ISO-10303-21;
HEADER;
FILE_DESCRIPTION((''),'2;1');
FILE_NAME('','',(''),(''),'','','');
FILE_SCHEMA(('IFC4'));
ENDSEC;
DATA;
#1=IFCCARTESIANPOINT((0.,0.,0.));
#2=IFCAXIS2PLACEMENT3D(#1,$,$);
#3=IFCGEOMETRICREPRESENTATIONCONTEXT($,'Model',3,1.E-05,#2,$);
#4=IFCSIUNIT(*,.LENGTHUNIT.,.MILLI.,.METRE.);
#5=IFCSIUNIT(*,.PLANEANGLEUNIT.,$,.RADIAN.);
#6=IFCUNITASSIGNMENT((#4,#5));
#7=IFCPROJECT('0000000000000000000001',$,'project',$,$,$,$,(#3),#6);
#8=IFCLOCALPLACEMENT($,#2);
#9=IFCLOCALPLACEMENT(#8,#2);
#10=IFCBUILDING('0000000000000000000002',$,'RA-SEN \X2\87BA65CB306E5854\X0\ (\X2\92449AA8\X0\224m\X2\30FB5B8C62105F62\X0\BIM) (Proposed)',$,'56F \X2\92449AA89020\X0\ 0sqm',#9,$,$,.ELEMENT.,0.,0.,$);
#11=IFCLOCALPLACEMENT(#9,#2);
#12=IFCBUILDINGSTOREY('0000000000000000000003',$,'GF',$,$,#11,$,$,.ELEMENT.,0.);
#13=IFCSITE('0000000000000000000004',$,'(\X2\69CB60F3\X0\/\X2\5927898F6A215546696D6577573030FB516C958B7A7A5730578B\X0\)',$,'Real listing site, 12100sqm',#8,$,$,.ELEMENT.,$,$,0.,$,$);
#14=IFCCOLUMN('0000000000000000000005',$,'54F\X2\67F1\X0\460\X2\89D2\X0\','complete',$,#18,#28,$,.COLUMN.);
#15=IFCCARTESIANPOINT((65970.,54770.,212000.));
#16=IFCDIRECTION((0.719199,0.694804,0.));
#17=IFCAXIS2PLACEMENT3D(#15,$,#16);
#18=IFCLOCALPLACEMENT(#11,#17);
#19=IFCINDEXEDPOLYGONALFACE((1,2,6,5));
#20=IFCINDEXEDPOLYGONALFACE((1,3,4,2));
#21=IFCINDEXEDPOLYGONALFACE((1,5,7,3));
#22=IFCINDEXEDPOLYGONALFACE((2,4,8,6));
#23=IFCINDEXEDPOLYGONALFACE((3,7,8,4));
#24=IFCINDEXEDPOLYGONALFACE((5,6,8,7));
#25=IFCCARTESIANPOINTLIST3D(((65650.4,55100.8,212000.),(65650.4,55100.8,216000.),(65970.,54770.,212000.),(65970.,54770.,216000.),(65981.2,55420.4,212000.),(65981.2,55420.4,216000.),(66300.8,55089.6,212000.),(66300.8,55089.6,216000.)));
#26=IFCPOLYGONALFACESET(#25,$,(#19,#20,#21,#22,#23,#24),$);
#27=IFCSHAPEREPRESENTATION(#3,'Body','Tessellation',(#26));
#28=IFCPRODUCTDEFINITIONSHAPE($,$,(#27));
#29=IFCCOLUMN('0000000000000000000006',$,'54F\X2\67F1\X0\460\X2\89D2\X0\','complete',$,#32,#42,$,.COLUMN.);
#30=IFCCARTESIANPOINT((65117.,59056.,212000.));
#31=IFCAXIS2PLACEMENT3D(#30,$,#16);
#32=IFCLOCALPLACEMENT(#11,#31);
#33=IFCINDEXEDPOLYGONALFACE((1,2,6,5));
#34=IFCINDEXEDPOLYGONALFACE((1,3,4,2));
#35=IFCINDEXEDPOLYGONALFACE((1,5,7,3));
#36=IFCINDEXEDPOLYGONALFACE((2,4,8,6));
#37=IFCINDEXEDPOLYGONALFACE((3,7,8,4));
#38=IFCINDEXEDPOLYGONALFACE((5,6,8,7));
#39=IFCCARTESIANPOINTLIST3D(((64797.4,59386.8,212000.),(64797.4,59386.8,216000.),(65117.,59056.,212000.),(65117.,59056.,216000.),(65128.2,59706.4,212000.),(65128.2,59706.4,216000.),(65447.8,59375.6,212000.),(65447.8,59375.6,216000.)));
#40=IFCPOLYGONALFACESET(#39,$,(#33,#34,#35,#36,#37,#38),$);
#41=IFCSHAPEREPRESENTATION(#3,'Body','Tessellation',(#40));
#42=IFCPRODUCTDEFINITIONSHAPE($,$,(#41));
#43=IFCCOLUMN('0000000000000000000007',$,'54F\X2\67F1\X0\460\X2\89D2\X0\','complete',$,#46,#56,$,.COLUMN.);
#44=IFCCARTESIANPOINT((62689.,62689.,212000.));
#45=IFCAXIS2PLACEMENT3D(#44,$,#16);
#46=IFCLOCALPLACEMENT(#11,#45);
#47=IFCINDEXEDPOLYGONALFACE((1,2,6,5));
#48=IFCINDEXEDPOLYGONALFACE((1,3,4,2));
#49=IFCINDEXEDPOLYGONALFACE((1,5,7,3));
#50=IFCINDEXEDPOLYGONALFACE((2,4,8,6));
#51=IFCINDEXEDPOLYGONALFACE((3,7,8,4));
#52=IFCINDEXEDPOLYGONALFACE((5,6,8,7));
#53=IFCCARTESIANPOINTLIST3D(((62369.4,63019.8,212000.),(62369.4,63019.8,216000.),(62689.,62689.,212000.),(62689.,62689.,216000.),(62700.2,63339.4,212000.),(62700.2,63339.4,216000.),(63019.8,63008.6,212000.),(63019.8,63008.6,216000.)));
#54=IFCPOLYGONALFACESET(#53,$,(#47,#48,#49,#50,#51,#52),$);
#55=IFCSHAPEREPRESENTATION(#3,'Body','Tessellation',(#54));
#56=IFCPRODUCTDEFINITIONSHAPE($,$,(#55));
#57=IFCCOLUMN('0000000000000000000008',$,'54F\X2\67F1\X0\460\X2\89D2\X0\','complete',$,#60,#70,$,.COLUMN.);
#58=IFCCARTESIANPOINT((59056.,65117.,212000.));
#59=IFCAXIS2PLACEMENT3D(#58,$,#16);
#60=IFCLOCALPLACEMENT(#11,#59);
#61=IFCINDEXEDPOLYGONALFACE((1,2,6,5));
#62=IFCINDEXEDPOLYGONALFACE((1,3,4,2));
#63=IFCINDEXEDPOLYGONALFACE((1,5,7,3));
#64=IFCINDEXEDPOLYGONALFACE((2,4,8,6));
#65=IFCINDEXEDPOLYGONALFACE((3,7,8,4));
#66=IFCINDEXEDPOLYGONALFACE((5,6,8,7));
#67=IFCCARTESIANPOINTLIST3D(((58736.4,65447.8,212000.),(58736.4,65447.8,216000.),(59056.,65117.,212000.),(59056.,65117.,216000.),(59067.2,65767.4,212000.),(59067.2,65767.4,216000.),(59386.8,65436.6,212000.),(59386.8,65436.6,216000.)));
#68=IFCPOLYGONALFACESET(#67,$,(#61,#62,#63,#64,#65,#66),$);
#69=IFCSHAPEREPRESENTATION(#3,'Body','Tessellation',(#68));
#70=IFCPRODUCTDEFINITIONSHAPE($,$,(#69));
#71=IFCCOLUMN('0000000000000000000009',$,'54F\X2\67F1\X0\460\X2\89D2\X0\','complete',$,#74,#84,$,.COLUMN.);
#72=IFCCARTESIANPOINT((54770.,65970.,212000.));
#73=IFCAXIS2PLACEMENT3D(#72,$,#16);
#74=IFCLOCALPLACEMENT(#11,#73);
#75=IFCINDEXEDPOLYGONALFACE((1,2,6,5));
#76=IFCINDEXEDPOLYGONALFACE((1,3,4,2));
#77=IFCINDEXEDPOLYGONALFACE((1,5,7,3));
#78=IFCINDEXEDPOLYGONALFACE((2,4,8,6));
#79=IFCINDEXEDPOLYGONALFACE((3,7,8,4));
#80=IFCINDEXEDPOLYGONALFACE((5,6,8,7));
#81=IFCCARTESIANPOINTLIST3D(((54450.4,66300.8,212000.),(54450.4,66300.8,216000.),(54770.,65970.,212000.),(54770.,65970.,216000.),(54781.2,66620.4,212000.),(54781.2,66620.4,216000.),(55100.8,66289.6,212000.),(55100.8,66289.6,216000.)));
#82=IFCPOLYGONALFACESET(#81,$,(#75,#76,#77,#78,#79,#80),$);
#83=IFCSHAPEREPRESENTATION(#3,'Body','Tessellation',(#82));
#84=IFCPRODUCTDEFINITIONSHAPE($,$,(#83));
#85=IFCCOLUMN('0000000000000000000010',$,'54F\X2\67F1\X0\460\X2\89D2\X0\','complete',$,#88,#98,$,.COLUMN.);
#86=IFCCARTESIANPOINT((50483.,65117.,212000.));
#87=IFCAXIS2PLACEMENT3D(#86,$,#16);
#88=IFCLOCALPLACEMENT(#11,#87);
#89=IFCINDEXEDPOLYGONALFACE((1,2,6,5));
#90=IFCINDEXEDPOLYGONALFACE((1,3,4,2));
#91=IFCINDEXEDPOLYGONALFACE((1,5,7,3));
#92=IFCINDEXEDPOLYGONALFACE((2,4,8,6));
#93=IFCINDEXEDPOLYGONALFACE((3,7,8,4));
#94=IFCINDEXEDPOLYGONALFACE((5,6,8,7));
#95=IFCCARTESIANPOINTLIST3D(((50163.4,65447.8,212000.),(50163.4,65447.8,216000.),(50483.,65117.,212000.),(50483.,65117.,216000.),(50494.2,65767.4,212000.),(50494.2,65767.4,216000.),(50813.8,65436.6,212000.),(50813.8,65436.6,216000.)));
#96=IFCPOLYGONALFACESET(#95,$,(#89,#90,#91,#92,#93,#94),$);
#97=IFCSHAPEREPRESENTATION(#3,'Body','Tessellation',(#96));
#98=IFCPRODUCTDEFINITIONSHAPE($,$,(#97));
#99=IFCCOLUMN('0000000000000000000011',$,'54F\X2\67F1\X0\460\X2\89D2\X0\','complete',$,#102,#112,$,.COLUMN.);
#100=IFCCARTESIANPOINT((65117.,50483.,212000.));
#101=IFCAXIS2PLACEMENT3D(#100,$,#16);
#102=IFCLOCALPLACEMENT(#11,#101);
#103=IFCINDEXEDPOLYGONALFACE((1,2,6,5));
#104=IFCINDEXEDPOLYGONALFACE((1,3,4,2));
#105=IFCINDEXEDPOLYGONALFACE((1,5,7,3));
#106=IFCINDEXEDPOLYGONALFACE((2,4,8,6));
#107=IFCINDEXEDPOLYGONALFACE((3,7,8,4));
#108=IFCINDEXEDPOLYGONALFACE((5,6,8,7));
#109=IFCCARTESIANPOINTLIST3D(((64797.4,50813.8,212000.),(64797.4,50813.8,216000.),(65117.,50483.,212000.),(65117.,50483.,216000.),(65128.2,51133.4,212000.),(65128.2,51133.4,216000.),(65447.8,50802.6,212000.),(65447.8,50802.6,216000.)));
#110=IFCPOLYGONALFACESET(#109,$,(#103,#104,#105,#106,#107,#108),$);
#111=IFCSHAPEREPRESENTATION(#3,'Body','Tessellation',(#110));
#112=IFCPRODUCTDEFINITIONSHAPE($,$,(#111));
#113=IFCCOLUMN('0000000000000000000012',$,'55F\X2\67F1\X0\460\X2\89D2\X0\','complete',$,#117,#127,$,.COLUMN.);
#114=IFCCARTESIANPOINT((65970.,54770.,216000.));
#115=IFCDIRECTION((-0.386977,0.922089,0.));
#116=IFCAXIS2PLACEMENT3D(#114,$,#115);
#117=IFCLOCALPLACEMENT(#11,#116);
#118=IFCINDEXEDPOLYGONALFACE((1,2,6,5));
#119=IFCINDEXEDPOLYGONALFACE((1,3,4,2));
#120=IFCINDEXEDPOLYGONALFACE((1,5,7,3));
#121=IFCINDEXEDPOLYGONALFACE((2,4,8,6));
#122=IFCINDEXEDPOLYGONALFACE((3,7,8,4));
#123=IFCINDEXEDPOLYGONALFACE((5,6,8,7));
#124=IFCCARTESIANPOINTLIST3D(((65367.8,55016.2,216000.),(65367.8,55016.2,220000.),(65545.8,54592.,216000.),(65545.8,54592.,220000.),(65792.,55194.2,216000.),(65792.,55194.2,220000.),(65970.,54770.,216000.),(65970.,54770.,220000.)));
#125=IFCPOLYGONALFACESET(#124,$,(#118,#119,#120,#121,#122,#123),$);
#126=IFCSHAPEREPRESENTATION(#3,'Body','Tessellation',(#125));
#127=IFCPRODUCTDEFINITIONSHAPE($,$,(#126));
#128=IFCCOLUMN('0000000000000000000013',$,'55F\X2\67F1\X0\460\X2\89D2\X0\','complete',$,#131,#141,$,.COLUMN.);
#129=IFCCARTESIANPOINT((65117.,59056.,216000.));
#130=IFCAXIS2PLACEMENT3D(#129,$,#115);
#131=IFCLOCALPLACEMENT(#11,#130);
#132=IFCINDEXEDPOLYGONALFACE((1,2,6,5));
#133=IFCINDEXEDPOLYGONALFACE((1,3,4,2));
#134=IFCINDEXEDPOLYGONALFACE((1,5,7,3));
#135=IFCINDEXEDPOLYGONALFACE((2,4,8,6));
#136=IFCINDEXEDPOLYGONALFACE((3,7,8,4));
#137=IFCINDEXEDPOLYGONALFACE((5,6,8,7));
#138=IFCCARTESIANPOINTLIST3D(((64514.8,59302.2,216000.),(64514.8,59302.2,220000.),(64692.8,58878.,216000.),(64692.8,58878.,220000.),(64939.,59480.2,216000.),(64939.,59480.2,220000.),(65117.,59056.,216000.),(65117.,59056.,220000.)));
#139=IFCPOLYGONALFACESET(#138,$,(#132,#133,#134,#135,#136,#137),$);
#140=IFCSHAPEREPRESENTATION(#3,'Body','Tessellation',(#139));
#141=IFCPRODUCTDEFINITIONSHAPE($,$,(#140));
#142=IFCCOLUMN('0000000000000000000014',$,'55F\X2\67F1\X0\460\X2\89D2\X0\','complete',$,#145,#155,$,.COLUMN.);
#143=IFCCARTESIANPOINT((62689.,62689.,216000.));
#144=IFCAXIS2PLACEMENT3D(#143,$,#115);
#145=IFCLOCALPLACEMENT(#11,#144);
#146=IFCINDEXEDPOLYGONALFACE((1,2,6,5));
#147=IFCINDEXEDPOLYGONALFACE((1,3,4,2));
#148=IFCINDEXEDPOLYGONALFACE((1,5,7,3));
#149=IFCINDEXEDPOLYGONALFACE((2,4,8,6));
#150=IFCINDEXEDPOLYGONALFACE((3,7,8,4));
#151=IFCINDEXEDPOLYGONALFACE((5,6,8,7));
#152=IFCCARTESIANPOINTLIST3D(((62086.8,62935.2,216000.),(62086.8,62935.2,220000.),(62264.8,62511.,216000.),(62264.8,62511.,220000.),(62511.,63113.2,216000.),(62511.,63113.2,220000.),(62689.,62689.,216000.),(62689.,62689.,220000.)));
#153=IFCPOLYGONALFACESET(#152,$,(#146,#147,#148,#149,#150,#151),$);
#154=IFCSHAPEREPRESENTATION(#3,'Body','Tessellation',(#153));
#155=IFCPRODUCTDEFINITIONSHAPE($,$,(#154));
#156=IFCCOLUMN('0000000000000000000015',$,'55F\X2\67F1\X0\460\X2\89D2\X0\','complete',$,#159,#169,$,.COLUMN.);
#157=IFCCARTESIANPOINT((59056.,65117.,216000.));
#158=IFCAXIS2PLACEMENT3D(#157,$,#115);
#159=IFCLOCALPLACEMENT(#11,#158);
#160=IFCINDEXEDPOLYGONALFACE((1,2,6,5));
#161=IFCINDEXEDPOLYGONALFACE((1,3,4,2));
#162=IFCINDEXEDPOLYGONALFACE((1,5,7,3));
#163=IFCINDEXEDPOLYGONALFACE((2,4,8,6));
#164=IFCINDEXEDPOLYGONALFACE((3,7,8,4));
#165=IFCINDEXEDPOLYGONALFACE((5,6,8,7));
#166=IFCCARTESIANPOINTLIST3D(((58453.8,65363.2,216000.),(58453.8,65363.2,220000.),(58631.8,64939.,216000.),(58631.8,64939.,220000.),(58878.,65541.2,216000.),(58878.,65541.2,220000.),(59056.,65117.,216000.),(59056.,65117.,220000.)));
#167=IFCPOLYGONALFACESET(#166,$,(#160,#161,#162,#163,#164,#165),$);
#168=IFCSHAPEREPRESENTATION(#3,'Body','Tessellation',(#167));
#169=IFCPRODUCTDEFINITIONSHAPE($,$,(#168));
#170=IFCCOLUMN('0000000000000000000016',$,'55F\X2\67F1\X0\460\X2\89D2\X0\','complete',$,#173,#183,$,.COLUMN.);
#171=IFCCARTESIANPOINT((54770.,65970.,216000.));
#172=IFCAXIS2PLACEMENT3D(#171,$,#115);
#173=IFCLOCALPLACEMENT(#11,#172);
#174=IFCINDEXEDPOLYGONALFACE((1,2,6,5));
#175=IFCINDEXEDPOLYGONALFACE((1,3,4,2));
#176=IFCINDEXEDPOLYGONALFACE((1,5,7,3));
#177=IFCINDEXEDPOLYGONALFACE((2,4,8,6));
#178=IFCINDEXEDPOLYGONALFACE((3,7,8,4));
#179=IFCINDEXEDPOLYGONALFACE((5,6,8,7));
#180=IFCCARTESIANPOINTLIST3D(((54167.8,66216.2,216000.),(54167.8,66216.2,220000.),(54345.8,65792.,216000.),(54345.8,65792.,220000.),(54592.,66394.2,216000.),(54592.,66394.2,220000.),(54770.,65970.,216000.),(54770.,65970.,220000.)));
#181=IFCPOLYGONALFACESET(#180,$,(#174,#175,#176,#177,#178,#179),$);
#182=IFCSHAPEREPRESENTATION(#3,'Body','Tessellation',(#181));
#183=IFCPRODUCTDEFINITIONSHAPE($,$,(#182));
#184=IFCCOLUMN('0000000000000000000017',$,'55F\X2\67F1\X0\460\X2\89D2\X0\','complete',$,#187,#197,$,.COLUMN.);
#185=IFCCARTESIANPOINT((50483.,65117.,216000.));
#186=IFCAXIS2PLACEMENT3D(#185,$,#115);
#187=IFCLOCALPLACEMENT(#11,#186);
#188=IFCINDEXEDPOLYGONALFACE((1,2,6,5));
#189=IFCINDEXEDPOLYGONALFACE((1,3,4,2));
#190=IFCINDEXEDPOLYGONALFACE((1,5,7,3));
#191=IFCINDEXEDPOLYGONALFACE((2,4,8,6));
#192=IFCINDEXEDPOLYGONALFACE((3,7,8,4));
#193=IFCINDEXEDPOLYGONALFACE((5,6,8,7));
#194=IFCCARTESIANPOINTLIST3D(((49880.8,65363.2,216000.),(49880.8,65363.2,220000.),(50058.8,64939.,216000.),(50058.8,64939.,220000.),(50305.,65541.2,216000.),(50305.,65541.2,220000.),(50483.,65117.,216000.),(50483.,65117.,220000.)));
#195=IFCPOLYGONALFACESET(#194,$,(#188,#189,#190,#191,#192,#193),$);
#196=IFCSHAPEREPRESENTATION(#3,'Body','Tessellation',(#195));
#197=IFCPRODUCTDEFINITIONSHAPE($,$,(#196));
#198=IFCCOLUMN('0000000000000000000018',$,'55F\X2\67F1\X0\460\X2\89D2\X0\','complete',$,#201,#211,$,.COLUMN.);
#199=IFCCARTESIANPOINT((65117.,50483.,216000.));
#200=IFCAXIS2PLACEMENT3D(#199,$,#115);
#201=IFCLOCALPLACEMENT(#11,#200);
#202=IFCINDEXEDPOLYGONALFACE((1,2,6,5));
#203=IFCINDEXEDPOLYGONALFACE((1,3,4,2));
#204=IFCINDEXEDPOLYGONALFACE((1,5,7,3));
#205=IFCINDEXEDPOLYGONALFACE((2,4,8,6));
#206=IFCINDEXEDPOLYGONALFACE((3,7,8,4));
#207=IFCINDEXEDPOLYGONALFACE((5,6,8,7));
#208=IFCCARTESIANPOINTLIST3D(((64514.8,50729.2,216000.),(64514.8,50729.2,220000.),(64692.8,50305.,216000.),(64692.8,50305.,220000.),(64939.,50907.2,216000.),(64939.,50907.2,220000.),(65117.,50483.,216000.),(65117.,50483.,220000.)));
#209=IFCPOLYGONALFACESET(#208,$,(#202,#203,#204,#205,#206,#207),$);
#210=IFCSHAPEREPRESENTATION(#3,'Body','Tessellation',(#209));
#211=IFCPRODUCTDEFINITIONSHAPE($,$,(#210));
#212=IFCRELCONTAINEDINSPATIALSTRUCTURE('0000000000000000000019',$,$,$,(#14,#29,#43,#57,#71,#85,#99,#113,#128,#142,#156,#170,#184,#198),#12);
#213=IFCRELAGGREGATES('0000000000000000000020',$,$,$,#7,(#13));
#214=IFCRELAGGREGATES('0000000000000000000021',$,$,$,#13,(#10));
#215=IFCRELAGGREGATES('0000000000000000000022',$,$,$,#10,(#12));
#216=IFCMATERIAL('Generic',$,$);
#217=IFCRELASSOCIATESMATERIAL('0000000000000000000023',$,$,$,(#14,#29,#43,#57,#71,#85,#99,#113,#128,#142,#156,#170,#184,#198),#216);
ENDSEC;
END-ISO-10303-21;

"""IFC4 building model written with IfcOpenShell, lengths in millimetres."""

from ifc_helpers import new_model, si_unit, frame, frame_2d, origin, place, context, project, spatial, rectangle, extrude, material, element, save


model = new_model("IFC4")

# Units and contexts
model_context = context("Model", 3, precision=1e-05, world=origin())
ifc_project = project(units=[si_unit("LENGTHUNIT", "METRE", prefix="MILLI"), si_unit("PLANEANGLEUNIT", "RADIAN")], contexts=[model_context])

# Site, building, storey
site_placement = place(None, origin())
site = spatial("IfcSite", under=ifc_project, at=site_placement, Name="(構想/大規模商業敷地・公開空地型)", ObjectType="Real listing site, 12100sqm", CompositionType="ELEMENT", RefElevation=0.0)
building_placement = place(site_placement, origin())
building = spatial("IfcBuilding", under=site, at=building_placement, Name="RA-SEN 螺旋の塔 (鉄骨224m・完成形BIM) (Proposed)", ObjectType="56F 鉄骨造 0sqm", CompositionType="ELEMENT", ElevationOfRefHeight=0.0, ElevationOfTerrain=0.0)
storey_placement = place(building_placement, origin())
storey = spatial("IfcBuildingStorey", under=building, at=storey_placement, Name="GF", CompositionType="ELEMENT", Elevation=0.0)

# Columns
ifc_material = material(Name="Generic")
column_1_placement = place(storey_placement, frame((65970.0, 54770.0, 212000.0), x_axis=(0.719199, 0.694804, 0.0)))
element("IfcColumn", 1, at=column_1_placement, inside=storey, material=ifc_material, Name="54F柱460角", Description="complete", PredefinedType="COLUMN", context=model_context, shape_type="SweptSolid", body=[
    extrude(rectangle(XDim=460.0, YDim=460.0, at=frame_2d((230.0, 230.0))), frame((65970.0, 54770.0, 212000.0), x_axis=(0.719199, 0.694804, 0.0)), (0.0, 0.0, 1.0), 4000.0),
])
column_2_placement = place(storey_placement, frame((65117.0, 59056.0, 212000.0), x_axis=(0.719199, 0.694804, 0.0)))
element("IfcColumn", 2, at=column_2_placement, inside=storey, material=ifc_material, Name="54F柱460角", Description="complete", PredefinedType="COLUMN", context=model_context, shape_type="SweptSolid", body=[
    extrude(rectangle(XDim=460.0, YDim=460.0, at=frame_2d((230.0, 230.0))), frame((65117.0, 59056.0, 212000.0), x_axis=(0.719199, 0.694804, 0.0)), (0.0, 0.0, 1.0), 4000.0),
])
column_3_placement = place(storey_placement, frame((62689.0, 62689.0, 212000.0), x_axis=(0.719199, 0.694804, 0.0)))
element("IfcColumn", 3, at=column_3_placement, inside=storey, material=ifc_material, Name="54F柱460角", Description="complete", PredefinedType="COLUMN", context=model_context, shape_type="SweptSolid", body=[
    extrude(rectangle(XDim=460.0, YDim=460.0, at=frame_2d((230.0, 230.0))), frame((62689.0, 62689.0, 212000.0), x_axis=(0.719199, 0.694804, 0.0)), (0.0, 0.0, 1.0), 4000.0),
])
column_4_placement = place(storey_placement, frame((59056.0, 65117.0, 212000.0), x_axis=(0.719199, 0.694804, 0.0)))
element("IfcColumn", 4, at=column_4_placement, inside=storey, material=ifc_material, Name="54F柱460角", Description="complete", PredefinedType="COLUMN", context=model_context, shape_type="SweptSolid", body=[
    extrude(rectangle(XDim=460.0, YDim=460.0, at=frame_2d((230.0, 230.0))), frame((59056.0, 65117.0, 212000.0), x_axis=(0.719199, 0.694804, 0.0)), (0.0, 0.0, 1.0), 4000.0),
])
column_5_placement = place(storey_placement, frame((54770.0, 65970.0, 212000.0), x_axis=(0.719199, 0.694804, 0.0)))
element("IfcColumn", 5, at=column_5_placement, inside=storey, material=ifc_material, Name="54F柱460角", Description="complete", PredefinedType="COLUMN", context=model_context, shape_type="SweptSolid", body=[
    extrude(rectangle(XDim=460.0, YDim=460.0, at=frame_2d((230.0, 230.0))), frame((54770.0, 65970.0, 212000.0), x_axis=(0.719199, 0.694804, 0.0)), (0.0, 0.0, 1.0), 4000.0),
])
column_6_placement = place(storey_placement, frame((50483.0, 65117.0, 212000.0), x_axis=(0.719199, 0.694804, 0.0)))
element("IfcColumn", 6, at=column_6_placement, inside=storey, material=ifc_material, Name="54F柱460角", Description="complete", PredefinedType="COLUMN", context=model_context, shape_type="SweptSolid", body=[
    extrude(rectangle(XDim=460.0, YDim=460.0, at=frame_2d((230.0, 230.0))), frame((50483.0, 65117.0, 212000.0), x_axis=(0.719199, 0.694804, 0.0)), (0.0, 0.0, 1.0), 4000.0),
])
column_7_placement = place(storey_placement, frame((65117.0, 50483.0, 212000.0), x_axis=(0.719199, 0.694804, 0.0)))
element("IfcColumn", 7, at=column_7_placement, inside=storey, material=ifc_material, Name="54F柱460角", Description="complete", PredefinedType="COLUMN", context=model_context, shape_type="SweptSolid", body=[
    extrude(rectangle(XDim=460.0, YDim=460.0, at=frame_2d((230.0, 230.0))), frame((65117.0, 50483.0, 212000.0), x_axis=(0.719199, 0.694804, 0.0)), (0.0, 0.0, 1.0), 4000.0),
])
column_8_placement = place(storey_placement, frame((65970.0, 54770.0, 216000.0), x_axis=(-0.386977, 0.922089, 0.0)))
element("IfcColumn", 8, at=column_8_placement, inside=storey, material=ifc_material, Name="55F柱460角", Description="complete", PredefinedType="COLUMN", context=model_context, shape_type="SweptSolid", body=[
    extrude(rectangle(XDim=460.0, YDim=460.0, at=frame_2d((230.0, 230.0))), frame((65970.0, 54770.0, 216000.0), x_axis=(-0.386977, 0.922089, 0.0)), (0.0, 0.0, 1.0), 4000.0),
])
column_9_placement = place(storey_placement, frame((65117.0, 59056.0, 216000.0), x_axis=(-0.386977, 0.922089, 0.0)))
element("IfcColumn", 9, at=column_9_placement, inside=storey, material=ifc_material, Name="55F柱460角", Description="complete", PredefinedType="COLUMN", context=model_context, shape_type="SweptSolid", body=[
    extrude(rectangle(XDim=460.0, YDim=460.0, at=frame_2d((230.0, 230.0))), frame((65117.0, 59056.0, 216000.0), x_axis=(-0.386977, 0.922089, 0.0)), (0.0, 0.0, 1.0), 4000.0),
])
column_10_placement = place(storey_placement, frame((62689.0, 62689.0, 216000.0), x_axis=(-0.386977, 0.922089, 0.0)))
element("IfcColumn", 10, at=column_10_placement, inside=storey, material=ifc_material, Name="55F柱460角", Description="complete", PredefinedType="COLUMN", context=model_context, shape_type="SweptSolid", body=[
    extrude(rectangle(XDim=460.0, YDim=460.0, at=frame_2d((230.0, 230.0))), frame((62689.0, 62689.0, 216000.0), x_axis=(-0.386977, 0.922089, 0.0)), (0.0, 0.0, 1.0), 4000.0),
])
column_11_placement = place(storey_placement, frame((59056.0, 65117.0, 216000.0), x_axis=(-0.386977, 0.922089, 0.0)))
element("IfcColumn", 11, at=column_11_placement, inside=storey, material=ifc_material, Name="55F柱460角", Description="complete", PredefinedType="COLUMN", context=model_context, shape_type="SweptSolid", body=[
    extrude(rectangle(XDim=460.0, YDim=460.0, at=frame_2d((230.0, 230.0))), frame((59056.0, 65117.0, 216000.0), x_axis=(-0.386977, 0.922089, 0.0)), (0.0, 0.0, 1.0), 4000.0),
])
column_12_placement = place(storey_placement, frame((54770.0, 65970.0, 216000.0), x_axis=(-0.386977, 0.922089, 0.0)))
element("IfcColumn", 12, at=column_12_placement, inside=storey, material=ifc_material, Name="55F柱460角", Description="complete", PredefinedType="COLUMN", context=model_context, shape_type="SweptSolid", body=[
    extrude(rectangle(XDim=460.0, YDim=460.0, at=frame_2d((230.0, 230.0))), frame((54770.0, 65970.0, 216000.0), x_axis=(-0.386977, 0.922089, 0.0)), (0.0, 0.0, 1.0), 4000.0),
])
column_13_placement = place(storey_placement, frame((50483.0, 65117.0, 216000.0), x_axis=(-0.386977, 0.922089, 0.0)))
element("IfcColumn", 13, at=column_13_placement, inside=storey, material=ifc_material, Name="55F柱460角", Description="complete", PredefinedType="COLUMN", context=model_context, shape_type="SweptSolid", body=[
    extrude(rectangle(XDim=460.0, YDim=460.0, at=frame_2d((230.0, 230.0))), frame((50483.0, 65117.0, 216000.0), x_axis=(-0.386977, 0.922089, 0.0)), (0.0, 0.0, 1.0), 4000.0),
])
column_14_placement = place(storey_placement, frame((65117.0, 50483.0, 216000.0), x_axis=(-0.386977, 0.922089, 0.0)))
element("IfcColumn", 14, at=column_14_placement, inside=storey, material=ifc_material, Name="55F柱460角", Description="complete", PredefinedType="COLUMN", context=model_context, shape_type="SweptSolid", body=[
    extrude(rectangle(XDim=460.0, YDim=460.0, at=frame_2d((230.0, 230.0))), frame((65117.0, 50483.0, 216000.0), x_axis=(-0.386977, 0.922089, 0.0)), (0.0, 0.0, 1.0), 4000.0),
])

save(model, "model.ifc")
